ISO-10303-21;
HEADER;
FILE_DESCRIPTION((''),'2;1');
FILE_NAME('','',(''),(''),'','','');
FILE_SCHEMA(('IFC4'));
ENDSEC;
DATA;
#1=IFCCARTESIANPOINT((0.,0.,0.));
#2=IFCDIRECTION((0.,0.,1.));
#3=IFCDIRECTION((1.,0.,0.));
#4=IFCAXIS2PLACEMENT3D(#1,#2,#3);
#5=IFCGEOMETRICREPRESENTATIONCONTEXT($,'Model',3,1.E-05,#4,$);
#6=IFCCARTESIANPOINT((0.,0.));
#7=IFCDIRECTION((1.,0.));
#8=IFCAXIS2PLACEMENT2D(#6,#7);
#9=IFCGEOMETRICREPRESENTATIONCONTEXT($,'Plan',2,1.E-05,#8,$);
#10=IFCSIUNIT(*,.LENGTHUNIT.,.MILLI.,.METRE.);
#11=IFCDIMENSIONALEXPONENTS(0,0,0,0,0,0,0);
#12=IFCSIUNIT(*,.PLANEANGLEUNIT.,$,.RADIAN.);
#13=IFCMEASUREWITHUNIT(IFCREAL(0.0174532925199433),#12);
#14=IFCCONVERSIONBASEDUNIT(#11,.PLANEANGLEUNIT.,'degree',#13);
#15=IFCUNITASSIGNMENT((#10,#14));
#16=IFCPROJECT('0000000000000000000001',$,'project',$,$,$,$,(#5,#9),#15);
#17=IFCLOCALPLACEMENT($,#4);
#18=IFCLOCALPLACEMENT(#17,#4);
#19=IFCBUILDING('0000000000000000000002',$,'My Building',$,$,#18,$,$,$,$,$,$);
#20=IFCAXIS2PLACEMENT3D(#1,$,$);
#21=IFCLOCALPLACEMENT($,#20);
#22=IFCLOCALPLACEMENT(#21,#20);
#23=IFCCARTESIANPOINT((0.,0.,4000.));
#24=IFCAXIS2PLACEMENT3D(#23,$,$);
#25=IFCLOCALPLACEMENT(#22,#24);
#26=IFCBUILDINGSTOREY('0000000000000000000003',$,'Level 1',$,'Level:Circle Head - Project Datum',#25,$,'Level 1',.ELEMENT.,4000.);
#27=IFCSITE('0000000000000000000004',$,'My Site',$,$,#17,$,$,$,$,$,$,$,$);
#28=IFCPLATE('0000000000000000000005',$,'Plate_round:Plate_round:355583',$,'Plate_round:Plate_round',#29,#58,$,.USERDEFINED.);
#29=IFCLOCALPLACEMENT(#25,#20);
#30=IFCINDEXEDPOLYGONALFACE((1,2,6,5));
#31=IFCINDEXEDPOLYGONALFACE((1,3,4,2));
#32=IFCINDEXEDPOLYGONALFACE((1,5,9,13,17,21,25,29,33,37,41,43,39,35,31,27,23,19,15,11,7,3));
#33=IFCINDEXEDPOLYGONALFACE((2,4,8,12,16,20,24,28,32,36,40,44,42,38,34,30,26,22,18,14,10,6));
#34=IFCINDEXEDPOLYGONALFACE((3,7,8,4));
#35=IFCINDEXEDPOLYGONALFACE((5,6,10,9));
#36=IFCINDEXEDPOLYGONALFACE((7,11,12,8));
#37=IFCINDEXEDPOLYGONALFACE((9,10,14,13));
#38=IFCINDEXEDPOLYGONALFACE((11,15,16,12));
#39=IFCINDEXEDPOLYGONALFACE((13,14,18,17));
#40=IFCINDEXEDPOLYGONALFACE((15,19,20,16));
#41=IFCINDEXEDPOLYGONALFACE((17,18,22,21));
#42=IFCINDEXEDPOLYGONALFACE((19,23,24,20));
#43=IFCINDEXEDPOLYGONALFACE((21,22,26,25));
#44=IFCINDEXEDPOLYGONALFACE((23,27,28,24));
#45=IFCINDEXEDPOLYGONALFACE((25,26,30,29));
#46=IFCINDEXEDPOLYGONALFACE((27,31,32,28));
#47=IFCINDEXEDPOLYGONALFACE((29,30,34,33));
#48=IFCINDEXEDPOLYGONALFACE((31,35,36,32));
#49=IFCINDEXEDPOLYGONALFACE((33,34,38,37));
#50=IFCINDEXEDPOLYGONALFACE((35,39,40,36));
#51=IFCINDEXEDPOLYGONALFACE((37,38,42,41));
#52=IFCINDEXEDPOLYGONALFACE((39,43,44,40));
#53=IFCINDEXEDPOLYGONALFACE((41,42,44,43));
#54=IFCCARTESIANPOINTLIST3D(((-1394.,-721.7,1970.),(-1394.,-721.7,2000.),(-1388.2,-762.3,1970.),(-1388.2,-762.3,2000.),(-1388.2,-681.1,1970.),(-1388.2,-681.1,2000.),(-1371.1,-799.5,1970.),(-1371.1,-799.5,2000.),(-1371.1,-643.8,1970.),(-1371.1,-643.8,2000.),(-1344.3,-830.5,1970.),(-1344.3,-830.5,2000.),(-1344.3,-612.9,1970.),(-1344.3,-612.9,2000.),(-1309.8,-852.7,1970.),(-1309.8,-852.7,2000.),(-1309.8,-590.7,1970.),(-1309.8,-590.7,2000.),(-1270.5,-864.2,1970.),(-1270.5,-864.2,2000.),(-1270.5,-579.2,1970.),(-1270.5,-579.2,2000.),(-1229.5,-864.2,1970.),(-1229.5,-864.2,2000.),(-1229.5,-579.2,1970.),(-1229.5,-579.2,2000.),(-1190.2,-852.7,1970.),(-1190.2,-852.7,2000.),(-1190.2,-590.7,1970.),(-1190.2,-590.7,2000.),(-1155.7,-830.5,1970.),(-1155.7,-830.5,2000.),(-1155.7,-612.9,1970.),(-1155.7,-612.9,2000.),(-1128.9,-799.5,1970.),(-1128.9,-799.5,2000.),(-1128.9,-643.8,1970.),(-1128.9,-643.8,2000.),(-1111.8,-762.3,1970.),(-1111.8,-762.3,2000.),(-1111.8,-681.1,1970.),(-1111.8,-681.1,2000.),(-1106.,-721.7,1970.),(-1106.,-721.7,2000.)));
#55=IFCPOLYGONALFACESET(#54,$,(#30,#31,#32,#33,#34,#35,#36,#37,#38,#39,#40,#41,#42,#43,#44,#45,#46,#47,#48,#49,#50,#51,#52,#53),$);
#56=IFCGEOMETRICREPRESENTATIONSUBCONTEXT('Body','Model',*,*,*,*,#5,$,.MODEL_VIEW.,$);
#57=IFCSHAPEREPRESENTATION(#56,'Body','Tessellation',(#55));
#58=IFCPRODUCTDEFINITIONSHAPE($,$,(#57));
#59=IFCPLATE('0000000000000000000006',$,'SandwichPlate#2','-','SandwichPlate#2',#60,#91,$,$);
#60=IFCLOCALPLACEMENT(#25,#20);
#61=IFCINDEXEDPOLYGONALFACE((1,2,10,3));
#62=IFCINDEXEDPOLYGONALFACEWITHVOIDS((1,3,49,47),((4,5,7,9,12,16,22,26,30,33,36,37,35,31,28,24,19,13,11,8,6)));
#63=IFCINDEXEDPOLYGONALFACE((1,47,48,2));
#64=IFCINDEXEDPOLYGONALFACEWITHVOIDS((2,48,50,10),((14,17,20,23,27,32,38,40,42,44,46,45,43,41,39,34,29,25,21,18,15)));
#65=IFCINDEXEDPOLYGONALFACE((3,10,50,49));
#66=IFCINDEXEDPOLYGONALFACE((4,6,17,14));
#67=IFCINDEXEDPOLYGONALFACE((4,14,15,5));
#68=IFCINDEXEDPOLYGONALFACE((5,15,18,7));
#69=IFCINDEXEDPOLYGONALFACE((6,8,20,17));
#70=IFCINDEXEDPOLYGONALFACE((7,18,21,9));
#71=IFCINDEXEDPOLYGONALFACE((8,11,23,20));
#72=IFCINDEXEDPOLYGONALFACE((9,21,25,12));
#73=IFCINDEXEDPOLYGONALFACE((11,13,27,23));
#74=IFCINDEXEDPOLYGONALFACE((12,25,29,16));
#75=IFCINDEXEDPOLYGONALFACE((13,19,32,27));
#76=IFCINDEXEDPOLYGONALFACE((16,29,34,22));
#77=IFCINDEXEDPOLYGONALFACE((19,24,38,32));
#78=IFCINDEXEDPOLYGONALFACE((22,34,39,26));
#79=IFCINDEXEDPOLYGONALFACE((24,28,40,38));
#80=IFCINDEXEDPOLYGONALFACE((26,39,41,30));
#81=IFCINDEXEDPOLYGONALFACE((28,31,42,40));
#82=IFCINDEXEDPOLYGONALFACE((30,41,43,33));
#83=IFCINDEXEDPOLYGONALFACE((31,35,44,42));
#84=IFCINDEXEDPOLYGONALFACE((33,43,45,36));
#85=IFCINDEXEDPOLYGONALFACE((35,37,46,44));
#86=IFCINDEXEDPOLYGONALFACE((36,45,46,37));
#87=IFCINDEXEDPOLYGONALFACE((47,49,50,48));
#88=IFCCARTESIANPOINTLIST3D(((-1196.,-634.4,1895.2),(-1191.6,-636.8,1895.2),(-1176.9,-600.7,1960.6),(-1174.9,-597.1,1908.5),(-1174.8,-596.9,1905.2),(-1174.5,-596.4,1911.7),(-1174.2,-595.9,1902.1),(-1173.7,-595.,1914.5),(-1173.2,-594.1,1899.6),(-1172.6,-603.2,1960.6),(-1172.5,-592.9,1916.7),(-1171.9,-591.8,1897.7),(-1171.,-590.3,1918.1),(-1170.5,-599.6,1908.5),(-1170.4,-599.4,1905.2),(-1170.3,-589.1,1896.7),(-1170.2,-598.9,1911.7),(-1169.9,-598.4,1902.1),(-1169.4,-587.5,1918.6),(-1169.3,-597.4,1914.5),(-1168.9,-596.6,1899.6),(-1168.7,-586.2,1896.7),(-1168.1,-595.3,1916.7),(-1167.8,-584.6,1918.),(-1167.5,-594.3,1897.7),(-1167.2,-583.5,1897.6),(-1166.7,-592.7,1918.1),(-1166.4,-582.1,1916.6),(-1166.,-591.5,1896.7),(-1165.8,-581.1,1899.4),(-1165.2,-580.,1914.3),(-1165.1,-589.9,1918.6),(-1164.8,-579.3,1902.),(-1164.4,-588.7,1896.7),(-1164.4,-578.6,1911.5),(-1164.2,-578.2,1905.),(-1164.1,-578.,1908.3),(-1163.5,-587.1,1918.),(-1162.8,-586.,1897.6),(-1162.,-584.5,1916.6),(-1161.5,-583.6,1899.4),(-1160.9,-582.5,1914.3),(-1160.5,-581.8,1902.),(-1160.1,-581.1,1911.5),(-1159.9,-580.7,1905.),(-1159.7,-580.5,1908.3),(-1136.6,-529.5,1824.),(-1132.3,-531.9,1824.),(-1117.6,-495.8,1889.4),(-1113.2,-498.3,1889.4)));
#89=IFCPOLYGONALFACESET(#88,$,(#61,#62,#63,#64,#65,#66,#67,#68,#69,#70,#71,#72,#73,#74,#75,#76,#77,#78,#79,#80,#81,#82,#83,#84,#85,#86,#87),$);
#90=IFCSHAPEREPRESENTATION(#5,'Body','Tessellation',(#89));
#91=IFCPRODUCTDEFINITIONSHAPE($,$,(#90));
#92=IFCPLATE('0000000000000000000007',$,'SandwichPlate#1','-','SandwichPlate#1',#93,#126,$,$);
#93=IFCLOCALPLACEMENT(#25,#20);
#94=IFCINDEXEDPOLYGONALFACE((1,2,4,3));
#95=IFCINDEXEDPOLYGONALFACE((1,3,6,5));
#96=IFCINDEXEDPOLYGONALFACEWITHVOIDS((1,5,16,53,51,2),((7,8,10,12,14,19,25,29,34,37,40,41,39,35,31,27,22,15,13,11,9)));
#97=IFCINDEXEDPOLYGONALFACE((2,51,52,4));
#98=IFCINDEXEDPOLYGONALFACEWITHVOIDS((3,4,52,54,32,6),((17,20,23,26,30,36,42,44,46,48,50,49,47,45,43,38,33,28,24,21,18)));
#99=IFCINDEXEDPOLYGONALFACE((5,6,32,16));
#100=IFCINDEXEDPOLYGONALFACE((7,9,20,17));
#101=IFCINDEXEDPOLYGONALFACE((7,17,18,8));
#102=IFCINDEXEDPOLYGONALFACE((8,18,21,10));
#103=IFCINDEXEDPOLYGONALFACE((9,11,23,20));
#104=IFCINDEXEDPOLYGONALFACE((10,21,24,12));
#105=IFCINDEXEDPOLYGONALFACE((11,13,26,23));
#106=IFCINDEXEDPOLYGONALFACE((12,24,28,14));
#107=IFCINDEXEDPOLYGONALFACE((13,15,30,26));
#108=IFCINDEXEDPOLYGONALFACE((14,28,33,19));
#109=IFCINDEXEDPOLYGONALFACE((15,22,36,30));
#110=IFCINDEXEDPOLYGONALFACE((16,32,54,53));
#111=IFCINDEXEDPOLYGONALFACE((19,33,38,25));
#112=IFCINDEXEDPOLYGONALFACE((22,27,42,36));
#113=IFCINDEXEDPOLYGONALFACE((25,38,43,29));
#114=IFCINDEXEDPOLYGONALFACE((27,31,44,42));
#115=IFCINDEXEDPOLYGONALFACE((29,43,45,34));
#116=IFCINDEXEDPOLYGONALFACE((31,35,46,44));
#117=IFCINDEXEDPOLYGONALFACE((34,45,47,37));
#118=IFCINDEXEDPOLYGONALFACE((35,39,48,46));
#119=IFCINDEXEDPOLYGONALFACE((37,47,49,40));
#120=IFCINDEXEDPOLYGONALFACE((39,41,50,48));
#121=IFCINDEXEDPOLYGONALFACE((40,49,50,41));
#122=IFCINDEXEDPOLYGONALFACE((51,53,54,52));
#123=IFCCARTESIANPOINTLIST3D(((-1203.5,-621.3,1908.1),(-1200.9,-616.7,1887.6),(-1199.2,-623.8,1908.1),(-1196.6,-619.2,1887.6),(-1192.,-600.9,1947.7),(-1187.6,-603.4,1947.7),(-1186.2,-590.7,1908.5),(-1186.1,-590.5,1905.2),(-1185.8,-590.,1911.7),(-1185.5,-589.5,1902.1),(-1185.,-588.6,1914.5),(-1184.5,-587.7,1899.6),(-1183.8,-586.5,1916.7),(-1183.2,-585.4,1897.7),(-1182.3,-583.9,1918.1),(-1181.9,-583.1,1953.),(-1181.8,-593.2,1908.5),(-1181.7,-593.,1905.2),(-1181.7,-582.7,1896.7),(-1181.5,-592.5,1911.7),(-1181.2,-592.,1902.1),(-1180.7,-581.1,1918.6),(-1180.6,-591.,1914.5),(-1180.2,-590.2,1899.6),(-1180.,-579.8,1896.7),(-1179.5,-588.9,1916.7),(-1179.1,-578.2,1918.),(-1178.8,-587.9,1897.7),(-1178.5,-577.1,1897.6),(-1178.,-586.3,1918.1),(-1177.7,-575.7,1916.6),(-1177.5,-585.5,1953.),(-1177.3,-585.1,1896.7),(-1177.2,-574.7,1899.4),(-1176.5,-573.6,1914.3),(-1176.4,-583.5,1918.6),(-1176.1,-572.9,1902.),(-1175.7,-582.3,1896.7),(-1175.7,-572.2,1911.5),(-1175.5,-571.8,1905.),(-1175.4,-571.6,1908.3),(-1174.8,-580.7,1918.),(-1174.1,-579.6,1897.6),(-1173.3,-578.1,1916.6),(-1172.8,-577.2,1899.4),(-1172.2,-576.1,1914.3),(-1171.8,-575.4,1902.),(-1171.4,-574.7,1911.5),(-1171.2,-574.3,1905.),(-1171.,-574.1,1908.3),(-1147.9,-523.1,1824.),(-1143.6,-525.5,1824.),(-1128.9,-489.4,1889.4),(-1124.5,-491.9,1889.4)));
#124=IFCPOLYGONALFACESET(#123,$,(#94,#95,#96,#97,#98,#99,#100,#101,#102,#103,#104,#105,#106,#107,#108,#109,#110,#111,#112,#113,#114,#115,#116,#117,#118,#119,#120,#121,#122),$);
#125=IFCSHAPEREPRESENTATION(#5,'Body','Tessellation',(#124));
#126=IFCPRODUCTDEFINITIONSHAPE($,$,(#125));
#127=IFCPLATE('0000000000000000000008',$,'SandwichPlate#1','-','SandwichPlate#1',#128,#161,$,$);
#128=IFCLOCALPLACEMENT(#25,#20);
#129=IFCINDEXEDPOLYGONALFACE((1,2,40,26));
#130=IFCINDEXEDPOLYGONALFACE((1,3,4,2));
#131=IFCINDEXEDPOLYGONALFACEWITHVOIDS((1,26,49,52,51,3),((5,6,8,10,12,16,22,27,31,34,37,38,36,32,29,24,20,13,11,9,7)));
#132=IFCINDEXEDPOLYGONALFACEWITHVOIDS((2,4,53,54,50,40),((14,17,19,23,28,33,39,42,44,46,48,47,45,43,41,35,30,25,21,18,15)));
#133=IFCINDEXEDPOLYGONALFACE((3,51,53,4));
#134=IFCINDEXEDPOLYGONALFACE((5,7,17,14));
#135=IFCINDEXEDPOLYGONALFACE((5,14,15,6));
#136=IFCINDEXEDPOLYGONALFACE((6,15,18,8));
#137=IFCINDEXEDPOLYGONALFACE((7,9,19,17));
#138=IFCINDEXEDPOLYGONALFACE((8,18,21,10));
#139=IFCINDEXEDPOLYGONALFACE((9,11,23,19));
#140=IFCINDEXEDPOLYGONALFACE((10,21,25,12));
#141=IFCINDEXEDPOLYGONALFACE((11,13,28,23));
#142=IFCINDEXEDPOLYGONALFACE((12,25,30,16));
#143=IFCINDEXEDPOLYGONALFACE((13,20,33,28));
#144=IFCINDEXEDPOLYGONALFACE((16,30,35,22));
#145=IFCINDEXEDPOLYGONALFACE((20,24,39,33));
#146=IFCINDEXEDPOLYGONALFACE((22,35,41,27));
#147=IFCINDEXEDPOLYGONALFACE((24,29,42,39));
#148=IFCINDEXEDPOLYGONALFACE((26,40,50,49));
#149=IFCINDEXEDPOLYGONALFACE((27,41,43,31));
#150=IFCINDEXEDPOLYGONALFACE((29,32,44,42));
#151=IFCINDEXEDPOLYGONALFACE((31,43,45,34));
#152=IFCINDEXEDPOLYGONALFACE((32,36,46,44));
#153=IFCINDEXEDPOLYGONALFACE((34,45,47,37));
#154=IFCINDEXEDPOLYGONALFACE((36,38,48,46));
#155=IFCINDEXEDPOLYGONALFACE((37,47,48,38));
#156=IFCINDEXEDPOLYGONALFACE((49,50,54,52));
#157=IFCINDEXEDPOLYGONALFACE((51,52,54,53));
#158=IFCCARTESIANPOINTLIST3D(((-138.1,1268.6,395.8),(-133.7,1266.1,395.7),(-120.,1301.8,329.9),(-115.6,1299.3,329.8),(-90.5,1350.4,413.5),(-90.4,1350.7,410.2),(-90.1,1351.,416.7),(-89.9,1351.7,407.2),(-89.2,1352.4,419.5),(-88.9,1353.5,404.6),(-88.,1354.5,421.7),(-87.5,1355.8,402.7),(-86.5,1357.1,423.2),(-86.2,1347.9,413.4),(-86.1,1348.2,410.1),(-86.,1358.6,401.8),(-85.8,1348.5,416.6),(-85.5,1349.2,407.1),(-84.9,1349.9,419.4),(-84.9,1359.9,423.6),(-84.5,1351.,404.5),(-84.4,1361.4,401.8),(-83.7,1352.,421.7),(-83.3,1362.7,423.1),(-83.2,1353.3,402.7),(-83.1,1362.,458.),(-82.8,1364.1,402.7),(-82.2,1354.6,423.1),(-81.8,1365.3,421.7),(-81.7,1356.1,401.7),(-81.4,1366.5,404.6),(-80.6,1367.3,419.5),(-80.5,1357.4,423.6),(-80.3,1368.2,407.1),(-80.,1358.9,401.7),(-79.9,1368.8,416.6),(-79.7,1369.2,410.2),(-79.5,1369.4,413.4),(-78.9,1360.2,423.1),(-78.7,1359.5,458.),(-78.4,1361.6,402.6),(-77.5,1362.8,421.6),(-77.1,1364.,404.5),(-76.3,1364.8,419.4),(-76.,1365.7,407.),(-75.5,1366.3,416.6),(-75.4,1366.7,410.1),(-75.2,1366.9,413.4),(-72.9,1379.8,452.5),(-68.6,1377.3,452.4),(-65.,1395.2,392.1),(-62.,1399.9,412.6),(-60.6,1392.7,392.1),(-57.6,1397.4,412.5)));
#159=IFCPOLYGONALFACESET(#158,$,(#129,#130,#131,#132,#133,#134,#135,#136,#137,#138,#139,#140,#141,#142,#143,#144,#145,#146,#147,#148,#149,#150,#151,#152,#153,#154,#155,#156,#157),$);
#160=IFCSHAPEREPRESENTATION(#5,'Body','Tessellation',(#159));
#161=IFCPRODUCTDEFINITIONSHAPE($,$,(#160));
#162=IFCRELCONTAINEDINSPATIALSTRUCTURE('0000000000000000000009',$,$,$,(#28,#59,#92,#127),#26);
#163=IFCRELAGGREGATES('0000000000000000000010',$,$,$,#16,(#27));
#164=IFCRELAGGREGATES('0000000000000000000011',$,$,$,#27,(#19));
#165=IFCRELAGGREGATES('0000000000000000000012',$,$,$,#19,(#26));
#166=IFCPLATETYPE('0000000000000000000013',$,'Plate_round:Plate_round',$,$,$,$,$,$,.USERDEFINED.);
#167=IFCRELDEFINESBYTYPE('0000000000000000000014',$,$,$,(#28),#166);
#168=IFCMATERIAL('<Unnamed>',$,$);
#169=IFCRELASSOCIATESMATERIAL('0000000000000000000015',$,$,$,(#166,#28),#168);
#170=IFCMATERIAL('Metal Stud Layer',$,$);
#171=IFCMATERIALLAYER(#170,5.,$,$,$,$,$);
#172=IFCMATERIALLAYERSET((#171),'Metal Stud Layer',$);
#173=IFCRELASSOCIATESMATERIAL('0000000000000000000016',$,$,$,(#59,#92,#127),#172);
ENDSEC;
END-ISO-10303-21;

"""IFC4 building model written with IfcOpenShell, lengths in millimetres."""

from ifc_helpers import new_model, entity, si_unit, converted_unit, frame, origin, origin_with_axes, origin_2d_with_axis, place, context, subcontext, project, spatial, polyline, arc, indexed_curve, circle, outline, extrude, source, transform, mapped, material, layer, layer_set, type_object, type_shapes, element, save


model = new_model("IFC4")

# Units and contexts
model_context = context("Model", 3, precision=1e-05, world=origin_with_axes())
plan_context = context("Plan", 2, precision=1e-05, world=origin_2d_with_axis())
body_context = subcontext(model_context, "Body", "Model", "MODEL_VIEW")
ifc_project = project(units=[si_unit("LENGTHUNIT", "METRE", prefix="MILLI"), converted_unit("PLANEANGLEUNIT", "degree", entity("IfcReal", 0.0174532925199433), si_unit("PLANEANGLEUNIT", "RADIAN"), dimensions=[0, 0, 0, 0, 0, 0, 0])], contexts=[model_context, plan_context])

# Site, building, storey
site_placement = place(None, origin_with_axes())
site = spatial("IfcSite", under=ifc_project, at=site_placement, Name="My Site")
building_placement = place(site_placement, origin_with_axes())
building = spatial("IfcBuilding", under=site, at=building_placement, Name="My Building")
placement_1 = place(None, origin())
placement_2 = place(placement_1, origin())
storey_placement = place(placement_2, frame((0.0, 0.0, 4000.0)))
storey = spatial("IfcBuildingStorey", under=building, at=storey_placement, Name="Level 1", ObjectType="Level:Circle Head - Project Datum", LongName="Level 1", CompositionType="ELEMENT", Elevation=4000.0)

# Plate
ifc_material_1 = material(Name="<Unnamed>")
plate_type = type_object("IfcPlateType", Name="Plate_round:Plate_round", PredefinedType="USERDEFINED", material=ifc_material_1)
shared_shape = source(origin(), body_context, "Body", "SweptSolid", [
    extrude(outline(indexed_curve([(-144.0, 0.0), (0.0, -144.0), (144.0, 0.0), (0.0, 144.0)], segments=[arc(1, 2, 3), arc(3, 4, 1)], self_intersect=False)), origin(), (0.0, 0.0, 1.0), 30.0),
])
type_shapes(plate_type, [shared_shape])
plate_1_placement = place(storey_placement, frame((-1250.0, -721.7, 1970.0)))
element("IfcPlate", 1, at=plate_1_placement, inside=storey, type_object=plate_type, material=ifc_material_1, Name="Plate_round:Plate_round:355583", ObjectType="Plate_round:Plate_round", PredefinedType="USERDEFINED", context=body_context, shape_type="MappedRepresentation", body=[
    mapped(shared_shape, transform((0.0, 0.0, 0.0), scale=1.0)),
])

# Shared definitions
ifc_material_2 = material(Name="Metal Stud Layer")

# Plates, openings
ifc_layer_1 = layer(ifc_material_2, 5.0)
ifc_layer_set_1 = layer_set([ifc_layer_1], Name="Metal Stud Layer")
plate_2_placement = place(storey_placement, frame((-1176.9, -600.7, 1960.6), z_axis=(0.87026, -0.492593, 0.0), x_axis=(-0.250667, -0.442852, -0.860841)))
plate_2 = element("IfcPlate", 2, at=plate_2_placement, inside=storey, material=ifc_layer_set_1, Name="SandwichPlate#2", Description="-", ObjectType="SandwichPlate#2", context=model_context, shape_type="SweptSolid", body=[
    extrude(outline(polyline([(0.0, 0.0), (76.0, 0.0), (76.0, 140.0), (0.0, 140.0), (0.0, 0.0)])), origin_with_axes(), (0.0, 0.0, 1.0), 5.0),
])
opening_1_placement = place(plate_2_placement, frame((38.0, 40.0, -0.5), z_axis=(0.0, 0.0, 1.0), x_axis=(0.0, 1.0, 0.0)))
element("IfcOpeningElement", 3, at=opening_1_placement, cuts=plate_2, ObjectType="Opening", context=model_context, shape_type="SweptSolid", body=[
    extrude(circle(Radius=11.0, at=origin_2d_with_axis()), origin(), (0.0, 0.0, 1.0), 6.0),
])
plate_3_placement = place(storey_placement, frame((-1188.2, -594.3, 1960.6), z_axis=(0.87026, -0.492593, 0.0), x_axis=(-0.250667, -0.442852, -0.860841)))
plate_3 = element("IfcPlate", 4, at=plate_3_placement, inside=storey, material=ifc_layer_set_1, Name="SandwichPlate#1", Description="-", ObjectType="SandwichPlate#1", context=model_context, shape_type="SweptSolid", body=[
    extrude(outline(polyline([(15.0, 0.0), (61.0, 0.0), (76.0, 15.0), (76.0, 140.0), (0.0, 140.0), (0.0, 15.0), (15.0, 0.0)])), origin_with_axes(), (0.0, 0.0, 1.0), 5.0),
])
opening_2_placement = place(plate_3_placement, frame((38.0, 40.0, -0.5), z_axis=(0.0, 0.0, 1.0), x_axis=(0.0, 1.0, 0.0)))
element("IfcOpeningElement", 5, at=opening_2_placement, cuts=plate_3, ObjectType="Opening", context=model_context, shape_type="SweptSolid", body=[
    extrude(circle(Radius=11.0, at=origin_2d_with_axis()), origin(), (0.0, 0.0, 1.0), 6.0),
])

# Plate, openings
plate_4_placement = place(storey_placement, frame((-58.4, 1406.5, 399.6), z_axis=(0.865935, -0.499948, -0.014432), x_axis=(-0.238139, -0.437501, 0.867112)))
plate_4 = element("IfcPlate", 6, at=plate_4_placement, inside=storey, material=ifc_layer_set_1, Name="SandwichPlate#1", Description="-", ObjectType="SandwichPlate#1", context=model_context, shape_type="SweptSolid", body=[
    extrude(outline(polyline([(0.0, 0.0), (76.0, 0.0), (76.0, 140.0), (0.0, 140.0), (0.0, 0.0)])), origin_with_axes(), (0.0, 0.0, 1.0), 5.0),
])
opening_3_placement = place(plate_4_placement, frame((0.0, 0.0, 0.0), z_axis=(0.0, 0.0, 1.0), x_axis=(1.0, 0.0, 0.0)))
element("IfcOpeningElement", 7, at=opening_3_placement, cuts=plate_4, ObjectType="Opening", context=model_context, shape_type="SweptSolid", body=[
    extrude(outline(polyline([(0.0, 0.0), (15.0, 0.0), (0.0, 15.0), (0.0, 0.0)])), origin(), (0.0, 0.0, 1.0), 5.0),
])
opening_4_placement = place(plate_4_placement, frame((0.0, 0.0, 0.0), z_axis=(0.0, 0.0, 1.0), x_axis=(1.0, 0.0, 0.0)))
element("IfcOpeningElement", 8, at=opening_4_placement, cuts=plate_4, ObjectType="Opening", context=model_context, shape_type="SweptSolid", body=[
    extrude(outline(polyline([(76.0, 0.0), (76.0, 15.0), (61.0, 0.0), (76.0, 0.0)])), origin(), (0.0, 0.0, 1.0), 5.0),
])
opening_5_placement = place(plate_4_placement, frame((38.0, 40.0, -0.5), z_axis=(0.0, 0.0, 1.0), x_axis=(0.0, 1.0, 0.0)))
element("IfcOpeningElement", 9, at=opening_5_placement, cuts=plate_4, ObjectType="Opening", context=model_context, shape_type="SweptSolid", body=[
    extrude(circle(Radius=11.0, at=origin_2d_with_axis()), origin(), (0.0, 0.0, 1.0), 6.0),
])

save(model, "model.ifc")
